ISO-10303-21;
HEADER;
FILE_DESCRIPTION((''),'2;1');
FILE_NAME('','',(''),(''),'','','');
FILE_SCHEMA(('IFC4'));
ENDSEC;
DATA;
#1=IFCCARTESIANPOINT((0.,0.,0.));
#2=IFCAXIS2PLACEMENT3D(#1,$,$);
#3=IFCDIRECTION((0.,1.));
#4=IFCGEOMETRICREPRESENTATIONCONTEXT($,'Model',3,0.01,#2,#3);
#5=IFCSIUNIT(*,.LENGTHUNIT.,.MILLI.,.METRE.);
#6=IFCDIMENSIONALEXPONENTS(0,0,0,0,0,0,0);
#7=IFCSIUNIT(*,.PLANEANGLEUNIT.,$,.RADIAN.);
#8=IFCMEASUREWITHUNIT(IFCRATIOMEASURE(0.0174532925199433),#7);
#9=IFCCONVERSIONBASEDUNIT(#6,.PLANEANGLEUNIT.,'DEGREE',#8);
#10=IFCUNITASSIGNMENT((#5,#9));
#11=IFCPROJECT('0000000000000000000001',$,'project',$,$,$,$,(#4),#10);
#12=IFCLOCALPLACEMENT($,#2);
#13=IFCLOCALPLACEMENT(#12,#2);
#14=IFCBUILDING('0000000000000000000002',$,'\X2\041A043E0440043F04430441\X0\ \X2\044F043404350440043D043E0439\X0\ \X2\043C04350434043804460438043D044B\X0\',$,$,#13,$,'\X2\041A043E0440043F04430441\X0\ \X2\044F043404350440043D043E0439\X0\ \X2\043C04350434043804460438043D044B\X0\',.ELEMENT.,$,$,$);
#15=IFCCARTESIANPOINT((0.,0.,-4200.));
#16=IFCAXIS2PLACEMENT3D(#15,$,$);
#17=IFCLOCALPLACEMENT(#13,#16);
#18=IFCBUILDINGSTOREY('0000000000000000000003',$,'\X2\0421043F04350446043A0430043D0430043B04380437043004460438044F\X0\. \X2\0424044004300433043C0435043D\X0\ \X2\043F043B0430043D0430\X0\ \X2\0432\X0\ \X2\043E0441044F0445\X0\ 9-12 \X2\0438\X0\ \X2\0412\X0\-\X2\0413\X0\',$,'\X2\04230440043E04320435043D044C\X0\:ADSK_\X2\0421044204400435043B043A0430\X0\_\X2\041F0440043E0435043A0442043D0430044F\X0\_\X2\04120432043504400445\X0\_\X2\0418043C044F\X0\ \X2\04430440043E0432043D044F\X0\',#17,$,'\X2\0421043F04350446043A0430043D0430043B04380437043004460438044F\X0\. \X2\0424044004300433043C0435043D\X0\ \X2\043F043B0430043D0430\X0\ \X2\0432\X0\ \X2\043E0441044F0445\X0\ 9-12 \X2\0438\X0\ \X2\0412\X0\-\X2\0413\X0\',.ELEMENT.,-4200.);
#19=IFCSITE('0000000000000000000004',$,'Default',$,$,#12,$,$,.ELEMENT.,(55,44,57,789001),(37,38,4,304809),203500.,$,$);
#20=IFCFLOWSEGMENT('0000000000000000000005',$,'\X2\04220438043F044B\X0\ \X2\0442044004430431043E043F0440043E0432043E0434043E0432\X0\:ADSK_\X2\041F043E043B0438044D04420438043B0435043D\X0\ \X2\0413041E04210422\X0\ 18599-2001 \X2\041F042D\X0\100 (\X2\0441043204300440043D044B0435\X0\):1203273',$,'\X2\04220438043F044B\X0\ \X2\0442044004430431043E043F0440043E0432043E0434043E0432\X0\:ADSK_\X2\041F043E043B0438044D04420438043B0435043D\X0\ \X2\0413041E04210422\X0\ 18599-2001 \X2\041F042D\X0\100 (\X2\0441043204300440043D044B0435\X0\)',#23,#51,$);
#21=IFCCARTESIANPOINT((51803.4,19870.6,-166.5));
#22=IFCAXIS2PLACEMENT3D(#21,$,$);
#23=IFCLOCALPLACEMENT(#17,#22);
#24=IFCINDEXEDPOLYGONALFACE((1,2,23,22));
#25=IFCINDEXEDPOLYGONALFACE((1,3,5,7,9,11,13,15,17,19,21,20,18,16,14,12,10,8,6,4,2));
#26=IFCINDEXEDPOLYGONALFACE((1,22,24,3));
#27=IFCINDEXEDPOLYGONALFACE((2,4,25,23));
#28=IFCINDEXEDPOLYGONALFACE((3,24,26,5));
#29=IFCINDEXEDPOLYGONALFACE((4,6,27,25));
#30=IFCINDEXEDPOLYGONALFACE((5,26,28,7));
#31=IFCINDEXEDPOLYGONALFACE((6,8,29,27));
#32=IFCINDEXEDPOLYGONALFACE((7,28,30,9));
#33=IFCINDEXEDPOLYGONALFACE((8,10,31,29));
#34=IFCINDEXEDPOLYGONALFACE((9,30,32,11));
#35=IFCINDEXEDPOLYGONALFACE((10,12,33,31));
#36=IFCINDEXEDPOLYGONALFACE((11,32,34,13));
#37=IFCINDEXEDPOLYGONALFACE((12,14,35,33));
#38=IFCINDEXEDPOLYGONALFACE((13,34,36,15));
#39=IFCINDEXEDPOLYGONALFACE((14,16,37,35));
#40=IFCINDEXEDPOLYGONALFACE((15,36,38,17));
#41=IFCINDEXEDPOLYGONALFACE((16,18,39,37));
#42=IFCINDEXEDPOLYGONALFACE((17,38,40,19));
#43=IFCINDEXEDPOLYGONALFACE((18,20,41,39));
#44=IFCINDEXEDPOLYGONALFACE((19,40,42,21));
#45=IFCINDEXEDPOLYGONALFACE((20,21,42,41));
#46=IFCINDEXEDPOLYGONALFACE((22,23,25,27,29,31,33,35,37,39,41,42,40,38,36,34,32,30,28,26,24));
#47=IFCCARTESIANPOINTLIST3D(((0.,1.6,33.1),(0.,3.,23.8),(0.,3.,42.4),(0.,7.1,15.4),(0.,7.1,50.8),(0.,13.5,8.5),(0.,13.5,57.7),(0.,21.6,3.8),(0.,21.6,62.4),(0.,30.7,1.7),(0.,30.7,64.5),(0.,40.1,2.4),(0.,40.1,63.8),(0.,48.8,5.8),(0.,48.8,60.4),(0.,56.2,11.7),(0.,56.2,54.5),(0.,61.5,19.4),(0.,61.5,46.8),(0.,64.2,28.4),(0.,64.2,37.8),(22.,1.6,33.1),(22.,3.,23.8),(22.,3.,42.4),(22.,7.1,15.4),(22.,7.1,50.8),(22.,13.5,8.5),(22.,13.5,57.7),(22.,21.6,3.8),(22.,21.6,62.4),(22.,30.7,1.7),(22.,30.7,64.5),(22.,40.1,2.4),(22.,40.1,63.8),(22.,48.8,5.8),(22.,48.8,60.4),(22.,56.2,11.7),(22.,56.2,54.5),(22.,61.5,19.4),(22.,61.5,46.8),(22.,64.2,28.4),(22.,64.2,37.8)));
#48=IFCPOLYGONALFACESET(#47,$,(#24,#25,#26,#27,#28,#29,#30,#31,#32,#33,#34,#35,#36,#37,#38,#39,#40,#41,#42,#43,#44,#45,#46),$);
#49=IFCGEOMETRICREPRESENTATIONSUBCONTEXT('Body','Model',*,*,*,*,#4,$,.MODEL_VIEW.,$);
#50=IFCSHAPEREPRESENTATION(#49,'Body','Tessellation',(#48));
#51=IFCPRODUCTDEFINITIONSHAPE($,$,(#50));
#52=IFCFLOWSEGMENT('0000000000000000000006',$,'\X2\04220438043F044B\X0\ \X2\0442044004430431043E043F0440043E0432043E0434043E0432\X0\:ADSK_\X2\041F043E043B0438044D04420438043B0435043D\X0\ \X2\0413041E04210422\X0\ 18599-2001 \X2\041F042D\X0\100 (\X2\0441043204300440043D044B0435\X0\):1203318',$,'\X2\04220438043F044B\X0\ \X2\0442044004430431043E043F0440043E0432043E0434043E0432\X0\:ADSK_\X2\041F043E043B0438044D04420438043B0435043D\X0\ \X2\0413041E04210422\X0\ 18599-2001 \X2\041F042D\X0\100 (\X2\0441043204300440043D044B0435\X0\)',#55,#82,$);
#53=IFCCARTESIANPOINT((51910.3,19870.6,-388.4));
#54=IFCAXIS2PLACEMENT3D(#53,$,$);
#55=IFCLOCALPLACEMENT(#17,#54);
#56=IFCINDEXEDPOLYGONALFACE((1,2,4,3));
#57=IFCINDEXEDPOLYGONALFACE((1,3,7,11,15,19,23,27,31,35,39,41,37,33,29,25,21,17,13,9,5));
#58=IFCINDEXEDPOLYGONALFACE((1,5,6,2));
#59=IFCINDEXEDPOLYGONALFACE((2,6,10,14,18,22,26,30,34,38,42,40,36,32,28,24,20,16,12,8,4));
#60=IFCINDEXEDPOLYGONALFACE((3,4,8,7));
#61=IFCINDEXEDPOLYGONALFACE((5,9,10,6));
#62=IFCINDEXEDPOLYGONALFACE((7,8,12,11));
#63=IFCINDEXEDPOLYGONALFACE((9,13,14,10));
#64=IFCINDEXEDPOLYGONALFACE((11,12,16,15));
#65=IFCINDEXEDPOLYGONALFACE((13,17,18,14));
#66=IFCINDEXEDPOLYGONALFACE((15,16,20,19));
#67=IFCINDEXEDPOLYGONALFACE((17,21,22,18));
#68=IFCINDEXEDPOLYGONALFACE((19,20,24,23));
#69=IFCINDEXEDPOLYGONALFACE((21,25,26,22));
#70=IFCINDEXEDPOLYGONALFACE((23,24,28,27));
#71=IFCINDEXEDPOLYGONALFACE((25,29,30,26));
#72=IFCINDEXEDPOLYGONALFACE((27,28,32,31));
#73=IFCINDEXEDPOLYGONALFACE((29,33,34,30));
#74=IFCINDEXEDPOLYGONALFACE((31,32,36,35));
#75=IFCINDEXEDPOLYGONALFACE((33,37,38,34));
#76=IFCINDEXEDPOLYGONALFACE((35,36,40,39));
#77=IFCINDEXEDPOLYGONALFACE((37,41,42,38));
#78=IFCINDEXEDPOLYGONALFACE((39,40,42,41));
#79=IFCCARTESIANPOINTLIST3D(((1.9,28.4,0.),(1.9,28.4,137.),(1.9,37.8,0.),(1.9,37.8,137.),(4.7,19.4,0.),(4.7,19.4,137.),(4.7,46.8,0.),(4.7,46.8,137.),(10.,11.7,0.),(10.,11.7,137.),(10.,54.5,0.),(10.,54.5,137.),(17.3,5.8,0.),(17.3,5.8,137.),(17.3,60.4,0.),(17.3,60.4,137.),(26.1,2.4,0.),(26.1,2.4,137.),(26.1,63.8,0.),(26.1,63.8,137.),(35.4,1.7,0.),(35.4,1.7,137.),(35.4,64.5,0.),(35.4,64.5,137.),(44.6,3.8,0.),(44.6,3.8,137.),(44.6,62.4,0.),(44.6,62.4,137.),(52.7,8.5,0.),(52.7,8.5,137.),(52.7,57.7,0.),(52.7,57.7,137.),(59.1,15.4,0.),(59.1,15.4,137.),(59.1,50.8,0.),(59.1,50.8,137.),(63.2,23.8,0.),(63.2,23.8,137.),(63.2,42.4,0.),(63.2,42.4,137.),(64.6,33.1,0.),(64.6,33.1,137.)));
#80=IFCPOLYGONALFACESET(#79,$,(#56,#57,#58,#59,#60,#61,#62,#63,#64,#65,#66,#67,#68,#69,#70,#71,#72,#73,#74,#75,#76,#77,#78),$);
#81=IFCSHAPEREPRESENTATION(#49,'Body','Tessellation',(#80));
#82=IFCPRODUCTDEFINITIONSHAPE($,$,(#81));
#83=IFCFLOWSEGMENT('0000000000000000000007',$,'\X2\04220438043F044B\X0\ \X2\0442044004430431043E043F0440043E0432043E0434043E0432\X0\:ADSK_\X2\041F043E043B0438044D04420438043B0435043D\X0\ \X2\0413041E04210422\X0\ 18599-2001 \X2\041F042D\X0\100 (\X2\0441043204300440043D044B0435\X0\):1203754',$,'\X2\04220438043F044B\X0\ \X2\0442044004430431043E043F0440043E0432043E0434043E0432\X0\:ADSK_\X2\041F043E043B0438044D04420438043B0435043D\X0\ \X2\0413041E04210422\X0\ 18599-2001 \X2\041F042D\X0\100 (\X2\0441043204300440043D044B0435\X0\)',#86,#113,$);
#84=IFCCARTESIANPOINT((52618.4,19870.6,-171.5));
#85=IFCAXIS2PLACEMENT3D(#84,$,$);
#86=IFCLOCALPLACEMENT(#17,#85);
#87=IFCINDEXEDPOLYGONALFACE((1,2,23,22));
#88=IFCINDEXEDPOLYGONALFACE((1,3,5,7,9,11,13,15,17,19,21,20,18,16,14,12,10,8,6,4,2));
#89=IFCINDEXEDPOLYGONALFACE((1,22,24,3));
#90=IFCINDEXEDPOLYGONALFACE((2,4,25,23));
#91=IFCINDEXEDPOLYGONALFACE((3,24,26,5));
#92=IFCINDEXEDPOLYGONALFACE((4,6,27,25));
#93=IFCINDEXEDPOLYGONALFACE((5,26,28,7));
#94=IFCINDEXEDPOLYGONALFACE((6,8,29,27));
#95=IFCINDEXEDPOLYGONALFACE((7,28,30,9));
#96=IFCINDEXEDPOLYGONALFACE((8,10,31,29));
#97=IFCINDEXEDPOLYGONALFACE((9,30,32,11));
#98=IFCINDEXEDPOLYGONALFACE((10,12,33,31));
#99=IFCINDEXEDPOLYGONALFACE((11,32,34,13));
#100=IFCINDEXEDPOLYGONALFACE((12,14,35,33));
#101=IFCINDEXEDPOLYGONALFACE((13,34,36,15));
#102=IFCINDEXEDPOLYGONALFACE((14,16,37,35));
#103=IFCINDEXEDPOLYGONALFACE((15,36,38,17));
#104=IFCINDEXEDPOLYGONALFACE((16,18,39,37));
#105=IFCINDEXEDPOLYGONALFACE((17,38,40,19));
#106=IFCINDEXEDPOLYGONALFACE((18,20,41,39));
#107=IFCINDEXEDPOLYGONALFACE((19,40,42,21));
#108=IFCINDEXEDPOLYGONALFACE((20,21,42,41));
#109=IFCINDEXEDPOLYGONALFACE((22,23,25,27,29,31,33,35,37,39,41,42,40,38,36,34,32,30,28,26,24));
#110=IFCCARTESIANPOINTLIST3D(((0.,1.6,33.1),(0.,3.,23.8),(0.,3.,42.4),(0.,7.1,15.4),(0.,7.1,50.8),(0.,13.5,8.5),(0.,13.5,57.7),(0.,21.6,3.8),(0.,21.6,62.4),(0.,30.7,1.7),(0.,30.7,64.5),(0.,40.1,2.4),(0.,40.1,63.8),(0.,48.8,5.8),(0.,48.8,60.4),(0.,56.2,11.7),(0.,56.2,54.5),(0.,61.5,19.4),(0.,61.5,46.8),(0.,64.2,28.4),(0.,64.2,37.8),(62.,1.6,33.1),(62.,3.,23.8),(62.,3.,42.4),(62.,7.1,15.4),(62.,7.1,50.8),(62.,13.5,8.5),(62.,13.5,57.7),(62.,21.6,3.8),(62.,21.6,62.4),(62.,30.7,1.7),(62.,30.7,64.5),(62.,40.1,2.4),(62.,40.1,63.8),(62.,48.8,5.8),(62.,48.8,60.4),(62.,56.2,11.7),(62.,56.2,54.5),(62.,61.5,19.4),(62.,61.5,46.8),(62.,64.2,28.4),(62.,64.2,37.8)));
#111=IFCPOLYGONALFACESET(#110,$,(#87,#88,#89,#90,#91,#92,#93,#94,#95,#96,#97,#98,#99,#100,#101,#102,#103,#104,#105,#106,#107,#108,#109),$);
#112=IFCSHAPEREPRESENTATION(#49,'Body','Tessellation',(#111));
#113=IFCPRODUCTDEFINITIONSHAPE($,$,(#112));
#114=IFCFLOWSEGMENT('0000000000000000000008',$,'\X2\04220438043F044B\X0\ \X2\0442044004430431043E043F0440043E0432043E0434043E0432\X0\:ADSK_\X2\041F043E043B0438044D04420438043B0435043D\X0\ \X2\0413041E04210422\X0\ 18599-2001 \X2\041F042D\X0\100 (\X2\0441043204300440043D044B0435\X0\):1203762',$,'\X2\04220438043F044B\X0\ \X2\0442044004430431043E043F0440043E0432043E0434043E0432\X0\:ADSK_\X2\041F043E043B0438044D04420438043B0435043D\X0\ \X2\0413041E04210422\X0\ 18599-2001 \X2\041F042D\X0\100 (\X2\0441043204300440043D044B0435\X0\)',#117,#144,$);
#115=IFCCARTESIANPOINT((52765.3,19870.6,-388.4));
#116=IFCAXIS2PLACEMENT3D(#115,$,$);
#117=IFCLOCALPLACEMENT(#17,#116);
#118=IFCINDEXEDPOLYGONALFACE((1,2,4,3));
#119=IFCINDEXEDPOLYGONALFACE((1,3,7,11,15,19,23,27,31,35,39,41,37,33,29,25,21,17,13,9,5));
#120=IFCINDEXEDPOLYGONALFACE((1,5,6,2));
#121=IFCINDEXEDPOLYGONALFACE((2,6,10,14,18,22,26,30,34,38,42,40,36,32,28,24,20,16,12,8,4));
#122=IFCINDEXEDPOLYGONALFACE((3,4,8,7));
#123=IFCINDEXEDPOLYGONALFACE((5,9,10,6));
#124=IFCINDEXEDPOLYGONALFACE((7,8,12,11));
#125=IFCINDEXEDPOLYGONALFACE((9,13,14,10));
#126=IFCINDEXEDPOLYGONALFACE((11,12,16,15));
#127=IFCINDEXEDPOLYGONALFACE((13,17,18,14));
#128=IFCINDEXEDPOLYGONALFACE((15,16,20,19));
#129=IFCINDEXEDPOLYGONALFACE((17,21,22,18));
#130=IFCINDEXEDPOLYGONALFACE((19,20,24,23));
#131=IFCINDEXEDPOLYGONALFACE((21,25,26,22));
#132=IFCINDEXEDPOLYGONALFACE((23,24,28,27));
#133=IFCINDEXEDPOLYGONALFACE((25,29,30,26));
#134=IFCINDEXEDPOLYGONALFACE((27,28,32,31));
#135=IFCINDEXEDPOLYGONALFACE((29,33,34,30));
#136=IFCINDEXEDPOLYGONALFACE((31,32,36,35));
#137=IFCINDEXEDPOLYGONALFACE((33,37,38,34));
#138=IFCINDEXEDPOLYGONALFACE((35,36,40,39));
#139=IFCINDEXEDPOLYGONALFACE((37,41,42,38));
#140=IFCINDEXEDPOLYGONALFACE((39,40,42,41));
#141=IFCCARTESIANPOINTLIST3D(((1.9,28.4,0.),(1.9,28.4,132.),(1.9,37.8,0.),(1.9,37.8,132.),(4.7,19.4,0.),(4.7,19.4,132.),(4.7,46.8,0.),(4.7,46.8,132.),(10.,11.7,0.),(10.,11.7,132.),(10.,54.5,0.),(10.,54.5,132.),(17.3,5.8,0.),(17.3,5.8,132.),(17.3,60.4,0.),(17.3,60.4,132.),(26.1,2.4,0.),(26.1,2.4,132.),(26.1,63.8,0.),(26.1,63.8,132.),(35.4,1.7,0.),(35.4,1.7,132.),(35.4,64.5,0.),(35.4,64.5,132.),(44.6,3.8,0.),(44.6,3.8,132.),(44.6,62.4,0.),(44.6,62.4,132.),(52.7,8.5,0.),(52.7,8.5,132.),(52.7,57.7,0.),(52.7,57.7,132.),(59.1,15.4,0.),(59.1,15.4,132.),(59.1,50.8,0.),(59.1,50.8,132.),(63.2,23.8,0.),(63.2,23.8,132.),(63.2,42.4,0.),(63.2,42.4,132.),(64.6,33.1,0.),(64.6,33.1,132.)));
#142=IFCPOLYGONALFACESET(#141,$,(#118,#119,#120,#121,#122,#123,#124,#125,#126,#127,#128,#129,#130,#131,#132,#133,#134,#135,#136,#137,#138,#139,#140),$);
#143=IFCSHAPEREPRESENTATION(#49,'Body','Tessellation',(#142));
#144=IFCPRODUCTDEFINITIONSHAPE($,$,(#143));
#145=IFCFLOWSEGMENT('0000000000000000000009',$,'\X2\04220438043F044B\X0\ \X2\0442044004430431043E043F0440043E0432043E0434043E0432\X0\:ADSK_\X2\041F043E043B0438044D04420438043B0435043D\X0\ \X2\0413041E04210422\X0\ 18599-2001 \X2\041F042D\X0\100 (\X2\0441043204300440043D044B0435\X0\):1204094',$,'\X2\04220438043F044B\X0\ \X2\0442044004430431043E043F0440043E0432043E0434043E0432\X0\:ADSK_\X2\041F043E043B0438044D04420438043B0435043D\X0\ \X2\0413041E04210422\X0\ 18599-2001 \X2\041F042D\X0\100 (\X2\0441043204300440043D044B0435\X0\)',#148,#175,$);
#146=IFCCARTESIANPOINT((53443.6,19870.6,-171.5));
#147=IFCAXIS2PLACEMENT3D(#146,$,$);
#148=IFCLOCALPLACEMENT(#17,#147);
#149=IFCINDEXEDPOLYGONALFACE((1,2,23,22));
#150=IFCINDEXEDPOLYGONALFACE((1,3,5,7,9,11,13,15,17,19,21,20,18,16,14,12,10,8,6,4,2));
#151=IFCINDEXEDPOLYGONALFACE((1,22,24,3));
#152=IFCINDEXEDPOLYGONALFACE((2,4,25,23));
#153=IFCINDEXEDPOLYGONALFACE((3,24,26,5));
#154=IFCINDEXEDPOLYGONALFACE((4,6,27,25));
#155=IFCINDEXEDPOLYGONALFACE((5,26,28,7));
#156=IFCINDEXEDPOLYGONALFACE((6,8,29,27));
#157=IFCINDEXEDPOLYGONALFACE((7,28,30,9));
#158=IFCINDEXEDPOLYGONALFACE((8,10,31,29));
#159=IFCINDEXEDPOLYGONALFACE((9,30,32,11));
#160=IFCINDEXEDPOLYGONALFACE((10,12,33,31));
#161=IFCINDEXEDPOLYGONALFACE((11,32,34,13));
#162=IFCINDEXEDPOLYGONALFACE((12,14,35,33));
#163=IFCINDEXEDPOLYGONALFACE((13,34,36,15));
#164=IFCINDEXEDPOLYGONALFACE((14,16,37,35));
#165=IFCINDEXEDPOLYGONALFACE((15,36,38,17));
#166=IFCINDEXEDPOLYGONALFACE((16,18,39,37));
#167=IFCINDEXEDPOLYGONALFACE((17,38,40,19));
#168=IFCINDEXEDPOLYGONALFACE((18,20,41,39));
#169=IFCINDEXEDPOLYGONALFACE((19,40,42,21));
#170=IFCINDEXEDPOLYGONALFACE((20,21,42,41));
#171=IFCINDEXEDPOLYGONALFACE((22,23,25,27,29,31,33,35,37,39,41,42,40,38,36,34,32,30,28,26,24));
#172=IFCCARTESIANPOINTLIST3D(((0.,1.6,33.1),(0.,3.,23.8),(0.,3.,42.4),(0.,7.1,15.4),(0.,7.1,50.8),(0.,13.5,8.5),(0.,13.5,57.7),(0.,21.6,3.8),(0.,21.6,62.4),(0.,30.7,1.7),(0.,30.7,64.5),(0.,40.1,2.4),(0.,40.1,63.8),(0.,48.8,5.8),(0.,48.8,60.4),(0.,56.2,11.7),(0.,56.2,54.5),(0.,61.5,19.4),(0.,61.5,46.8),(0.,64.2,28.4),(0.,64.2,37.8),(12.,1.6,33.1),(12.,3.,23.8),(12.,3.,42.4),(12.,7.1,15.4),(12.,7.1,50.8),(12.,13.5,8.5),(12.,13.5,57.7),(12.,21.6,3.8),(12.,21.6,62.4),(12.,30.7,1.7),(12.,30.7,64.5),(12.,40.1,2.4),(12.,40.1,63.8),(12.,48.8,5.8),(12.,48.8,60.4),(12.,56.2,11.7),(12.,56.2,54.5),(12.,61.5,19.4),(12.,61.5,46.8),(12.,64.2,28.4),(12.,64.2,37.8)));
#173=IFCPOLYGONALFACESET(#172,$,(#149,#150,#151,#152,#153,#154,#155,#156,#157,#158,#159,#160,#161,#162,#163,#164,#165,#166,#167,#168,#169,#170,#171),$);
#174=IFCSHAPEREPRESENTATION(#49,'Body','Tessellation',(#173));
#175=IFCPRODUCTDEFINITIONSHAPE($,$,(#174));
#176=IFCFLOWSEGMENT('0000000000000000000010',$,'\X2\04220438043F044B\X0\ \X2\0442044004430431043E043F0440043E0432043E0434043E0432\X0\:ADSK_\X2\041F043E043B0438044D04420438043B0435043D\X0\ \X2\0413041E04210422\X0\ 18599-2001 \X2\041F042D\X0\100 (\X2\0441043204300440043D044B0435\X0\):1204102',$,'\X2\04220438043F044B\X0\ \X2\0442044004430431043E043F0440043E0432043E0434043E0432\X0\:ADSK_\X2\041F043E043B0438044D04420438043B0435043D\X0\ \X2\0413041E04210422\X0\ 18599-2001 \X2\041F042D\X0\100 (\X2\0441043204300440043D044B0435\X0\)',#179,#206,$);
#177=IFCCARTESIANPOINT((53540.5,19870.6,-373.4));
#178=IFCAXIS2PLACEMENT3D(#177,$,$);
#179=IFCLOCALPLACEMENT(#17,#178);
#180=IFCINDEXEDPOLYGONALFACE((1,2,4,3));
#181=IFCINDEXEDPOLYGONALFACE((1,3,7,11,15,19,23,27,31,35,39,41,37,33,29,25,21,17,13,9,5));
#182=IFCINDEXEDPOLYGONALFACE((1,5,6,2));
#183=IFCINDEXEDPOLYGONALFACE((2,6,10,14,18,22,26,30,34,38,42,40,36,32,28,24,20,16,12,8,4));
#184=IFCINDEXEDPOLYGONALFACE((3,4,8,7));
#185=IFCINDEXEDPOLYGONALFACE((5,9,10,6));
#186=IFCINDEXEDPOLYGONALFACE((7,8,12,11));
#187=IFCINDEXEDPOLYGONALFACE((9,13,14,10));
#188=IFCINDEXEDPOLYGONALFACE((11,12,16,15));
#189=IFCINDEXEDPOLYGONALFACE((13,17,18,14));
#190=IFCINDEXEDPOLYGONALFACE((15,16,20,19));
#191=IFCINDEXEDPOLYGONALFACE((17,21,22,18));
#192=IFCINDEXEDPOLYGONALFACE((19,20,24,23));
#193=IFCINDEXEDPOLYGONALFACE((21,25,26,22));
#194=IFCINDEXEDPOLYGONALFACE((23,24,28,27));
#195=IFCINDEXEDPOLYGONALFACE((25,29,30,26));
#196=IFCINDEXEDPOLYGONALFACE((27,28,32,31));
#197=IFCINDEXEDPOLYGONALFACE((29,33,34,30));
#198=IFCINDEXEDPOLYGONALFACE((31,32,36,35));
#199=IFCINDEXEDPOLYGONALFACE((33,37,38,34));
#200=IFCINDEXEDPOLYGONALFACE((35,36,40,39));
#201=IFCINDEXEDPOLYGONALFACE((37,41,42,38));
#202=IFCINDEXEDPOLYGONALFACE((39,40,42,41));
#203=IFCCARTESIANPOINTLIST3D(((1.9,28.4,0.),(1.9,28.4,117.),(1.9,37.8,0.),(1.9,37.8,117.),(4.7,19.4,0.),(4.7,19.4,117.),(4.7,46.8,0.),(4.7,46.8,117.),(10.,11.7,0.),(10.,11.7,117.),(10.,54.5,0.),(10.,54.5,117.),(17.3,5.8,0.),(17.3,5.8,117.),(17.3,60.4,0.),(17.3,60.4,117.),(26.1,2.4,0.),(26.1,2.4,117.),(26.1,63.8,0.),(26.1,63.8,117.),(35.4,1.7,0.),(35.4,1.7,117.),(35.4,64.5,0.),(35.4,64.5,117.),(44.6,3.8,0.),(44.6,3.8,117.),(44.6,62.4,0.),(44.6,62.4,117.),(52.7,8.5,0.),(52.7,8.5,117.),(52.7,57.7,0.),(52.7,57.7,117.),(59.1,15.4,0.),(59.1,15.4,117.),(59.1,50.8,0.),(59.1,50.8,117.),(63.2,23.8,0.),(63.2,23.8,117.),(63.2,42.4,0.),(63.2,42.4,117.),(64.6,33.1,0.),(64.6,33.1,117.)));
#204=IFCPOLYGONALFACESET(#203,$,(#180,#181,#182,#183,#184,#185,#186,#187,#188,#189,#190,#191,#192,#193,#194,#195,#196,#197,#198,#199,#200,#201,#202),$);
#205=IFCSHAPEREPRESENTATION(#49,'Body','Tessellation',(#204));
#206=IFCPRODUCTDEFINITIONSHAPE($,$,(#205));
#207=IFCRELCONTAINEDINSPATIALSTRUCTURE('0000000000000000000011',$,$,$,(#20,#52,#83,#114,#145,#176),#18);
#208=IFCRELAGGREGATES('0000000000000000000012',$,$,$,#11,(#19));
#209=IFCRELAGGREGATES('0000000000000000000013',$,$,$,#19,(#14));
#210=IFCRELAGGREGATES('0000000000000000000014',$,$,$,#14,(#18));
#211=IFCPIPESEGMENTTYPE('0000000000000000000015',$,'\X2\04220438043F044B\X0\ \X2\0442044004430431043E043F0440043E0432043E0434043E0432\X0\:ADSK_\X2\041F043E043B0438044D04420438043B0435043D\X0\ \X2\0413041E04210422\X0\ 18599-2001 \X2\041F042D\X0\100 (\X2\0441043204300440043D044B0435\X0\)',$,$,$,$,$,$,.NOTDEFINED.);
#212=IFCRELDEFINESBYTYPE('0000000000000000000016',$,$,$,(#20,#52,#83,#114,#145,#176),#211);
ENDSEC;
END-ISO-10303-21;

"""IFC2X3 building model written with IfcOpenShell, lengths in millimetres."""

from ifc_helpers import new_model, entity, si_unit, converted_unit, direction, frame, frame_2d, origin, origin_2d_with_axis, place, context, subcontext, project, spatial, circle, extrude, type_object, element, save


model = new_model("IFC2X3")

# Units and contexts
model_context = context("Model", 3, precision=0.01, world=origin(), true_north=direction((0.0, 1.0)))
body_context = subcontext(model_context, "Body", "Model", "MODEL_VIEW")
ifc_project = project(units=[si_unit("LENGTHUNIT", "METRE", prefix="MILLI"), converted_unit("PLANEANGLEUNIT", "DEGREE", entity("IfcRatioMeasure", 0.0174532925199433), si_unit("PLANEANGLEUNIT", "RADIAN"), dimensions=[0, 0, 0, 0, 0, 0, 0])], contexts=[model_context])

# Site, building, storey
site_placement = place(None, frame((0.0, 0.0, 0.0)))
site = spatial("IfcSite", under=ifc_project, at=site_placement, Name="Default", CompositionType="ELEMENT", RefLatitude=(55, 44, 57, 789001), RefLongitude=(37, 38, 4, 304809), RefElevation=203500.0)
building_placement = place(site_placement, origin())
building = spatial("IfcBuilding", under=site, at=building_placement, Name="Корпус ядерной медицины", LongName="Корпус ядерной медицины", CompositionType="ELEMENT")
storey_placement = place(building_placement, frame((0.0, 0.0, -4200.0)))
storey = spatial("IfcBuildingStorey", under=building, at=storey_placement, Name="Спецканализация. Фрагмен плана в осях 9-12 и В-Г", ObjectType="Уровень:ADSK_Стрелка_Проектная_Вверх_Имя уровня", LongName="Спецканализация. Фрагмен плана в осях 9-12 и В-Г", CompositionType="ELEMENT", Elevation=-4200.0)

# Flow segments
pipe_segment_type = type_object("IfcPipeSegmentType", Name="Типы трубопроводов:ADSK_Полиэтилен ГОСТ 18599-2001 ПЭ100 (сварные)", PredefinedType="NOTDEFINED")
flow_segment_1_placement = place(storey_placement, frame((51803.4, 19870.6, -166.5)))
element("IfcFlowSegment", 1, at=flow_segment_1_placement, inside=storey, type_object=pipe_segment_type, Name="Типы трубопроводов:ADSK_Полиэтилен ГОСТ 18599-2001 ПЭ100 (сварные):1203273", ObjectType="Типы трубопроводов:ADSK_Полиэтилен ГОСТ 18599-2001 ПЭ100 (сварные)", context=body_context, shape_type="SweptSolid", body=[
    extrude(circle(Radius=31.5, at=frame_2d((0.0, 0.0), x_axis=(1.0, 0.0))), frame((0.0, 33.1, 33.1), z_axis=(1.0, 0.0, 0.0), x_axis=(0.0, -1.0, 0.0)), (0.0, 0.0, 1.0), 22.0),
])
flow_segment_2_placement = place(storey_placement, frame((51910.3, 19870.6, -388.4)))
element("IfcFlowSegment", 2, at=flow_segment_2_placement, inside=storey, type_object=pipe_segment_type, Name="Типы трубопроводов:ADSK_Полиэтилен ГОСТ 18599-2001 ПЭ100 (сварные):1203318", ObjectType="Типы трубопроводов:ADSK_Полиэтилен ГОСТ 18599-2001 ПЭ100 (сварные)", context=body_context, shape_type="SweptSolid", body=[
    extrude(circle(Radius=31.5, at=origin_2d_with_axis()), frame((33.1, 33.1, 0.0)), (0.0, 0.0, 1.0), 137.0),
])
flow_segment_3_placement = place(storey_placement, frame((52618.4, 19870.6, -171.5)))
element("IfcFlowSegment", 3, at=flow_segment_3_placement, inside=storey, type_object=pipe_segment_type, Name="Типы трубопроводов:ADSK_Полиэтилен ГОСТ 18599-2001 ПЭ100 (сварные):1203754", ObjectType="Типы трубопроводов:ADSK_Полиэтилен ГОСТ 18599-2001 ПЭ100 (сварные)", context=body_context, shape_type="SweptSolid", body=[
    extrude(circle(Radius=31.5, at=origin_2d_with_axis()), frame((0.0, 33.1, 33.1), z_axis=(1.0, 0.0, 0.0), x_axis=(0.0, -1.0, 0.0)), (0.0, 0.0, 1.0), 62.0),
])
flow_segment_4_placement = place(storey_placement, frame((52765.3, 19870.6, -388.4)))
element("IfcFlowSegment", 4, at=flow_segment_4_placement, inside=storey, type_object=pipe_segment_type, Name="Типы трубопроводов:ADSK_Полиэтилен ГОСТ 18599-2001 ПЭ100 (сварные):1203762", ObjectType="Типы трубопроводов:ADSK_Полиэтилен ГОСТ 18599-2001 ПЭ100 (сварные)", context=body_context, shape_type="SweptSolid", body=[
    extrude(circle(Radius=31.5, at=origin_2d_with_axis()), frame((33.1, 33.1, 0.0)), (0.0, 0.0, 1.0), 132.0),
])
flow_segment_5_placement = place(storey_placement, frame((53443.6, 19870.6, -171.5)))
element("IfcFlowSegment", 5, at=flow_segment_5_placement, inside=storey, type_object=pipe_segment_type, Name="Типы трубопроводов:ADSK_Полиэтилен ГОСТ 18599-2001 ПЭ100 (сварные):1204094", ObjectType="Типы трубопроводов:ADSK_Полиэтилен ГОСТ 18599-2001 ПЭ100 (сварные)", context=body_context, shape_type="SweptSolid", body=[
    extrude(circle(Radius=31.5, at=origin_2d_with_axis()), frame((0.0, 33.1, 33.1), z_axis=(1.0, 0.0, 0.0), x_axis=(0.0, -1.0, 0.0)), (0.0, 0.0, 1.0), 12.0),
])
flow_segment_6_placement = place(storey_placement, frame((53540.5, 19870.6, -373.4)))
element("IfcFlowSegment", 6, at=flow_segment_6_placement, inside=storey, type_object=pipe_segment_type, Name="Типы трубопроводов:ADSK_Полиэтилен ГОСТ 18599-2001 ПЭ100 (сварные):1204102", ObjectType="Типы трубопроводов:ADSK_Полиэтилен ГОСТ 18599-2001 ПЭ100 (сварные)", context=body_context, shape_type="SweptSolid", body=[
    extrude(circle(Radius=31.5, at=origin_2d_with_axis()), frame((33.1, 33.1, 0.0)), (0.0, 0.0, 1.0), 117.0),
])

save(model, "model.ifc")
